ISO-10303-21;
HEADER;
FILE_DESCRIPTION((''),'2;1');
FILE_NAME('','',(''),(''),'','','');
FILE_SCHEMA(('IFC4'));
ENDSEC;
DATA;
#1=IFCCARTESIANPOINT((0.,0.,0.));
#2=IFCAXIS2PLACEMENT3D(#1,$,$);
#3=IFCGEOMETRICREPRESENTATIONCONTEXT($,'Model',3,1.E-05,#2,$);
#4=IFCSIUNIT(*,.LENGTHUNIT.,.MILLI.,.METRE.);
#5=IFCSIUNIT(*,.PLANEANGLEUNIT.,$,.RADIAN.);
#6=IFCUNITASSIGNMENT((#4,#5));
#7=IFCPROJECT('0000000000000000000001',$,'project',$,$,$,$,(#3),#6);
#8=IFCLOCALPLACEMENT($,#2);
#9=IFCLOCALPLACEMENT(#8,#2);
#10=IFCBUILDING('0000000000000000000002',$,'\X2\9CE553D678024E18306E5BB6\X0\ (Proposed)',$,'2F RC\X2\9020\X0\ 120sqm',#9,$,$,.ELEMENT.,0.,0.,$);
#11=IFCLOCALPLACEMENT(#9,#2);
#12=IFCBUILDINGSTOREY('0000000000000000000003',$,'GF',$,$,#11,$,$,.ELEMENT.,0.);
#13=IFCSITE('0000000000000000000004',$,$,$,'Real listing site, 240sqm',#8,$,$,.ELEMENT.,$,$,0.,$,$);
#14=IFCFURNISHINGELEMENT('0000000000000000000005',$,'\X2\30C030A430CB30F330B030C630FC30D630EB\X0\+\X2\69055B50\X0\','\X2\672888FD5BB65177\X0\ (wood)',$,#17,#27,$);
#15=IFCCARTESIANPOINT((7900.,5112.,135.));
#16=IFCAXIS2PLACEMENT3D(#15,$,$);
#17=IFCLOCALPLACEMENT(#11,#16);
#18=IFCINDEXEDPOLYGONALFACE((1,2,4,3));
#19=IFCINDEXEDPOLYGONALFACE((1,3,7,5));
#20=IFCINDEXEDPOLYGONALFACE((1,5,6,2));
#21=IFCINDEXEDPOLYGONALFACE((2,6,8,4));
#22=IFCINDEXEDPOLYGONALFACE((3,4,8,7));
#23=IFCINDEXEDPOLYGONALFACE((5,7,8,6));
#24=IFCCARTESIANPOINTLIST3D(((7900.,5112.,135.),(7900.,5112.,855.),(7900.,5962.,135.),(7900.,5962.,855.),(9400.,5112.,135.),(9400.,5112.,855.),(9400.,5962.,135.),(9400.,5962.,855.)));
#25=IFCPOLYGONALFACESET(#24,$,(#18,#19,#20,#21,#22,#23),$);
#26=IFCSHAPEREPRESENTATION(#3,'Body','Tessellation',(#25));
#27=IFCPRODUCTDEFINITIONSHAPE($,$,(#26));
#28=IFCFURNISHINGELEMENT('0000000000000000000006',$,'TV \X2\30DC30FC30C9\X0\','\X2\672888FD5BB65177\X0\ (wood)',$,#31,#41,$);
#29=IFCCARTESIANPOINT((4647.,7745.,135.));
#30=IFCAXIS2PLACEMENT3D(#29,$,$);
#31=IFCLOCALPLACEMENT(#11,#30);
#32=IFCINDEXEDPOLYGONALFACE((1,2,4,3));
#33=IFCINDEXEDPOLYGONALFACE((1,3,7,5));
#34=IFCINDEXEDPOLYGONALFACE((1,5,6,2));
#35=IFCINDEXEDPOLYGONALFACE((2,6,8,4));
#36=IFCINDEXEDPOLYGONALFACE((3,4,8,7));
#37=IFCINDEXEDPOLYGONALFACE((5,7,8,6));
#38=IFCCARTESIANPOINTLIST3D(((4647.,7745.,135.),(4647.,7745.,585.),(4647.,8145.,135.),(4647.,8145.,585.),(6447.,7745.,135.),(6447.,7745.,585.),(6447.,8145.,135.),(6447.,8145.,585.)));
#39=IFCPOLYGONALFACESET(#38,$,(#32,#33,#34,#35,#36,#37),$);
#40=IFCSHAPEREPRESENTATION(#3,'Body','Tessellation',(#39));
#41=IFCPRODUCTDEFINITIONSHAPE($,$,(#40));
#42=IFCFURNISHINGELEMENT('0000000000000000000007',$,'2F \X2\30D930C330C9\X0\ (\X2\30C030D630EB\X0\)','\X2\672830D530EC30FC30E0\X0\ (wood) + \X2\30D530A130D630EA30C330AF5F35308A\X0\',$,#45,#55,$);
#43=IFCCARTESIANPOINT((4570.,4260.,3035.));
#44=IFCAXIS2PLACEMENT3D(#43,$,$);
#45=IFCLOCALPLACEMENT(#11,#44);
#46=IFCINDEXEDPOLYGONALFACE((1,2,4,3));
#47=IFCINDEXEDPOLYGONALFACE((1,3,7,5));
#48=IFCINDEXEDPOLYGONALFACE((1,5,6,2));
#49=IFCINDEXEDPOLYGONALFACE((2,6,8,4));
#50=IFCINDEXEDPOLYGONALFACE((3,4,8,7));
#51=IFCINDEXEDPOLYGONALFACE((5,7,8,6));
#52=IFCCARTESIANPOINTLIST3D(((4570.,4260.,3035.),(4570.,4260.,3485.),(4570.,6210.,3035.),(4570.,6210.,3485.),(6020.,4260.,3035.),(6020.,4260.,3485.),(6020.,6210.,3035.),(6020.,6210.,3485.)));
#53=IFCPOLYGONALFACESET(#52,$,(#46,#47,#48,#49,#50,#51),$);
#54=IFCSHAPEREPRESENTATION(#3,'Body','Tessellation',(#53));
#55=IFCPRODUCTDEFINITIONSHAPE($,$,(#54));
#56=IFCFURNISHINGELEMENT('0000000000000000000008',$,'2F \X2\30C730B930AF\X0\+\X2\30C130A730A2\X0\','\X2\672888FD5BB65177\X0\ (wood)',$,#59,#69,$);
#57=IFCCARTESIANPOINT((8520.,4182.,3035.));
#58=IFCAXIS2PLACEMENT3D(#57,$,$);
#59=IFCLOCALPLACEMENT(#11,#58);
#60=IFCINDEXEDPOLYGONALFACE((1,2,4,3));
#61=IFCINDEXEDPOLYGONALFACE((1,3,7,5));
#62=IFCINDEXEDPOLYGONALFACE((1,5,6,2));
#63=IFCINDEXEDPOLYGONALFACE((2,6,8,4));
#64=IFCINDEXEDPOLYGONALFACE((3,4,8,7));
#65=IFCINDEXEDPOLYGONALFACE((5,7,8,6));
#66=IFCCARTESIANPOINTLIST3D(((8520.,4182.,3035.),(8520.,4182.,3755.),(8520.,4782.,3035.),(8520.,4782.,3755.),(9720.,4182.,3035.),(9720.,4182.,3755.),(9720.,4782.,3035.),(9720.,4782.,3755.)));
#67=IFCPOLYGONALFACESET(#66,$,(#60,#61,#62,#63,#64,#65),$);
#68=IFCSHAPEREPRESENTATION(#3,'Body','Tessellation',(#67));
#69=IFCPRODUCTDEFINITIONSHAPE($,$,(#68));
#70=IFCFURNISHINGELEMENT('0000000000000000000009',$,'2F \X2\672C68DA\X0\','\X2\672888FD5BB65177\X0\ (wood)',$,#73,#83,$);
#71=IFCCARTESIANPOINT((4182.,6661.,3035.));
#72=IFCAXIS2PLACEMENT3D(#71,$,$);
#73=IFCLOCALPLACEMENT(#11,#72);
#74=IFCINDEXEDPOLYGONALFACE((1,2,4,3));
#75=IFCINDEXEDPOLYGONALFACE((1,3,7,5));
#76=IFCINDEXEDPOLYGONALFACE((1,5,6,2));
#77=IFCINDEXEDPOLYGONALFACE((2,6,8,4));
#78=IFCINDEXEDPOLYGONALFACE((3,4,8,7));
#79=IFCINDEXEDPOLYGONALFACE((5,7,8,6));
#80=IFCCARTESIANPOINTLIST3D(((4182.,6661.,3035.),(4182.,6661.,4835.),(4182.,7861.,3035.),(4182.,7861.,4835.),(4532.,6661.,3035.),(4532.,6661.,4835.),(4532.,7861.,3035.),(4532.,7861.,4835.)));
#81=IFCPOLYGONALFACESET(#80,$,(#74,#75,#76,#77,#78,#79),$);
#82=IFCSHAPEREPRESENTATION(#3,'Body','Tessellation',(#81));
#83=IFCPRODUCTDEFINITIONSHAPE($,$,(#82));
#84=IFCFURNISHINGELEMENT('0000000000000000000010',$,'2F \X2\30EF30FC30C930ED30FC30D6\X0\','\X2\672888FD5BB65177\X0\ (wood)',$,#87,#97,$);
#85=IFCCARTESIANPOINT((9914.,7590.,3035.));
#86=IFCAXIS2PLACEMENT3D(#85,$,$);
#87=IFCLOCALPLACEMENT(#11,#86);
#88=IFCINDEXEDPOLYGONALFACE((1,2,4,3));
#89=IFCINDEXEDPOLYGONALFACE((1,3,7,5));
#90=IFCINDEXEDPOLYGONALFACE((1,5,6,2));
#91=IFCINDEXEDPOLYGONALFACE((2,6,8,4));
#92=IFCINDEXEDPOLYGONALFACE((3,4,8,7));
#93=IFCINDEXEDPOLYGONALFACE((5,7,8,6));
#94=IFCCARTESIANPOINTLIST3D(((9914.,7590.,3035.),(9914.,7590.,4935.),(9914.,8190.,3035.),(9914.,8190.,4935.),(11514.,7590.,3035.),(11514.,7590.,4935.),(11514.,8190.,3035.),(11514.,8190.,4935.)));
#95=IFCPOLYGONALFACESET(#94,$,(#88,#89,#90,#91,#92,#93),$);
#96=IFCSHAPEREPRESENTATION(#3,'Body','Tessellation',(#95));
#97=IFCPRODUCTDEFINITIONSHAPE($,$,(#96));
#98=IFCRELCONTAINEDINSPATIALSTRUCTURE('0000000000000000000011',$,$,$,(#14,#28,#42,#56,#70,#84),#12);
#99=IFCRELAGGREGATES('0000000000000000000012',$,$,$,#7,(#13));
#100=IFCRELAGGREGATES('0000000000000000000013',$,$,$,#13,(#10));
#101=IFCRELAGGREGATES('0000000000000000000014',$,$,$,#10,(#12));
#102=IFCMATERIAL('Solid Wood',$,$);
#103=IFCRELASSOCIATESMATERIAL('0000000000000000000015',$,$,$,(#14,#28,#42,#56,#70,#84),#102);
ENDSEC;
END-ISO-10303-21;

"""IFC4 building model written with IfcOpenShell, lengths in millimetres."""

from ifc_helpers import new_model, si_unit, frame, frame_2d, origin, place, context, project, spatial, rectangle, extrude, material, element, save


model = new_model("IFC4")

# Units and contexts
model_context = context("Model", 3, precision=1e-05, world=origin())
ifc_project = project(units=[si_unit("LENGTHUNIT", "METRE", prefix="MILLI"), si_unit("PLANEANGLEUNIT", "RADIAN")], contexts=[model_context])

# Site, building, storey
site_placement = place(None, origin())
site = spatial("IfcSite", under=ifc_project, at=site_placement, ObjectType="Real listing site, 240sqm", CompositionType="ELEMENT", RefElevation=0.0)
building_placement = place(site_placement, origin())
building = spatial("IfcBuilding", under=site, at=building_placement, Name="鳥取砂丘の家 (Proposed)", ObjectType="2F RC造 120sqm", CompositionType="ELEMENT", ElevationOfRefHeight=0.0, ElevationOfTerrain=0.0)
storey_placement = place(building_placement, origin())
storey = spatial("IfcBuildingStorey", under=building, at=storey_placement, Name="GF", CompositionType="ELEMENT", Elevation=0.0)

# Shared definitions
ifc_material_1 = material(Name="Solid Wood")

# Furnishing elements
furnishing_1_placement = place(storey_placement, frame((7900.0, 5112.0, 135.0)))
element("IfcFurnishingElement", 1, at=furnishing_1_placement, inside=storey, material=ifc_material_1, Name="ダイニングテーブル+椅子", Description="木製家具 (wood)", context=model_context, shape_type="SweptSolid", body=[
    extrude(rectangle(XDim=1500.0, YDim=850.0, at=frame_2d((750.0, 425.0))), frame((7900.0, 5112.0, 135.0)), (0.0, 0.0, 1.0), 720.0),
])
furnishing_2_placement = place(storey_placement, frame((4647.0, 7745.0, 135.0)))
element("IfcFurnishingElement", 2, at=furnishing_2_placement, inside=storey, material=ifc_material_1, Name="TV ボード", Description="木製家具 (wood)", context=model_context, shape_type="SweptSolid", body=[
    extrude(rectangle(XDim=1800.0, YDim=400.0, at=frame_2d((900.0, 200.0))), frame((4647.0, 7745.0, 135.0)), (0.0, 0.0, 1.0), 450.0),
])
furnishing_3_placement = place(storey_placement, frame((4570.0, 4260.0, 3035.0)))
element("IfcFurnishingElement", 3, at=furnishing_3_placement, inside=storey, material=ifc_material_1, Name="2F ベッド (ダブル)", Description="木フレーム (wood) + ファブリック張り", context=model_context, shape_type="SweptSolid", body=[
    extrude(rectangle(XDim=1450.0, YDim=1950.0, at=frame_2d((725.0, 975.0))), frame((4570.0, 4260.0, 3035.0)), (0.0, 0.0, 1.0), 450.0),
])
furnishing_4_placement = place(storey_placement, frame((8520.0, 4182.0, 3035.0)))
element("IfcFurnishingElement", 4, at=furnishing_4_placement, inside=storey, material=ifc_material_1, Name="2F デスク+チェア", Description="木製家具 (wood)", context=model_context, shape_type="SweptSolid", body=[
    extrude(rectangle(XDim=1200.0, YDim=600.0, at=frame_2d((600.0, 300.0))), frame((8520.0, 4182.0, 3035.0)), (0.0, 0.0, 1.0), 720.0),
])
furnishing_5_placement = place(storey_placement, frame((4182.0, 6661.0, 3035.0)))
element("IfcFurnishingElement", 5, at=furnishing_5_placement, inside=storey, material=ifc_material_1, Name="2F 本棚", Description="木製家具 (wood)", context=model_context, shape_type="SweptSolid", body=[
    extrude(rectangle(XDim=350.0, YDim=1200.0, at=frame_2d((175.0, 600.0))), frame((4182.0, 6661.0, 3035.0)), (0.0, 0.0, 1.0), 1800.0),
])
furnishing_6_placement = place(storey_placement, frame((9914.0, 7590.0, 3035.0)))
element("IfcFurnishingElement", 6, at=furnishing_6_placement, inside=storey, material=ifc_material_1, Name="2F ワードローブ", Description="木製家具 (wood)", context=model_context, shape_type="SweptSolid", body=[
    extrude(rectangle(XDim=1600.0, YDim=600.0, at=frame_2d((800.0, 300.0))), frame((9914.0, 7590.0, 3035.0)), (0.0, 0.0, 1.0), 1900.0),
])

save(model, "model.ifc")
